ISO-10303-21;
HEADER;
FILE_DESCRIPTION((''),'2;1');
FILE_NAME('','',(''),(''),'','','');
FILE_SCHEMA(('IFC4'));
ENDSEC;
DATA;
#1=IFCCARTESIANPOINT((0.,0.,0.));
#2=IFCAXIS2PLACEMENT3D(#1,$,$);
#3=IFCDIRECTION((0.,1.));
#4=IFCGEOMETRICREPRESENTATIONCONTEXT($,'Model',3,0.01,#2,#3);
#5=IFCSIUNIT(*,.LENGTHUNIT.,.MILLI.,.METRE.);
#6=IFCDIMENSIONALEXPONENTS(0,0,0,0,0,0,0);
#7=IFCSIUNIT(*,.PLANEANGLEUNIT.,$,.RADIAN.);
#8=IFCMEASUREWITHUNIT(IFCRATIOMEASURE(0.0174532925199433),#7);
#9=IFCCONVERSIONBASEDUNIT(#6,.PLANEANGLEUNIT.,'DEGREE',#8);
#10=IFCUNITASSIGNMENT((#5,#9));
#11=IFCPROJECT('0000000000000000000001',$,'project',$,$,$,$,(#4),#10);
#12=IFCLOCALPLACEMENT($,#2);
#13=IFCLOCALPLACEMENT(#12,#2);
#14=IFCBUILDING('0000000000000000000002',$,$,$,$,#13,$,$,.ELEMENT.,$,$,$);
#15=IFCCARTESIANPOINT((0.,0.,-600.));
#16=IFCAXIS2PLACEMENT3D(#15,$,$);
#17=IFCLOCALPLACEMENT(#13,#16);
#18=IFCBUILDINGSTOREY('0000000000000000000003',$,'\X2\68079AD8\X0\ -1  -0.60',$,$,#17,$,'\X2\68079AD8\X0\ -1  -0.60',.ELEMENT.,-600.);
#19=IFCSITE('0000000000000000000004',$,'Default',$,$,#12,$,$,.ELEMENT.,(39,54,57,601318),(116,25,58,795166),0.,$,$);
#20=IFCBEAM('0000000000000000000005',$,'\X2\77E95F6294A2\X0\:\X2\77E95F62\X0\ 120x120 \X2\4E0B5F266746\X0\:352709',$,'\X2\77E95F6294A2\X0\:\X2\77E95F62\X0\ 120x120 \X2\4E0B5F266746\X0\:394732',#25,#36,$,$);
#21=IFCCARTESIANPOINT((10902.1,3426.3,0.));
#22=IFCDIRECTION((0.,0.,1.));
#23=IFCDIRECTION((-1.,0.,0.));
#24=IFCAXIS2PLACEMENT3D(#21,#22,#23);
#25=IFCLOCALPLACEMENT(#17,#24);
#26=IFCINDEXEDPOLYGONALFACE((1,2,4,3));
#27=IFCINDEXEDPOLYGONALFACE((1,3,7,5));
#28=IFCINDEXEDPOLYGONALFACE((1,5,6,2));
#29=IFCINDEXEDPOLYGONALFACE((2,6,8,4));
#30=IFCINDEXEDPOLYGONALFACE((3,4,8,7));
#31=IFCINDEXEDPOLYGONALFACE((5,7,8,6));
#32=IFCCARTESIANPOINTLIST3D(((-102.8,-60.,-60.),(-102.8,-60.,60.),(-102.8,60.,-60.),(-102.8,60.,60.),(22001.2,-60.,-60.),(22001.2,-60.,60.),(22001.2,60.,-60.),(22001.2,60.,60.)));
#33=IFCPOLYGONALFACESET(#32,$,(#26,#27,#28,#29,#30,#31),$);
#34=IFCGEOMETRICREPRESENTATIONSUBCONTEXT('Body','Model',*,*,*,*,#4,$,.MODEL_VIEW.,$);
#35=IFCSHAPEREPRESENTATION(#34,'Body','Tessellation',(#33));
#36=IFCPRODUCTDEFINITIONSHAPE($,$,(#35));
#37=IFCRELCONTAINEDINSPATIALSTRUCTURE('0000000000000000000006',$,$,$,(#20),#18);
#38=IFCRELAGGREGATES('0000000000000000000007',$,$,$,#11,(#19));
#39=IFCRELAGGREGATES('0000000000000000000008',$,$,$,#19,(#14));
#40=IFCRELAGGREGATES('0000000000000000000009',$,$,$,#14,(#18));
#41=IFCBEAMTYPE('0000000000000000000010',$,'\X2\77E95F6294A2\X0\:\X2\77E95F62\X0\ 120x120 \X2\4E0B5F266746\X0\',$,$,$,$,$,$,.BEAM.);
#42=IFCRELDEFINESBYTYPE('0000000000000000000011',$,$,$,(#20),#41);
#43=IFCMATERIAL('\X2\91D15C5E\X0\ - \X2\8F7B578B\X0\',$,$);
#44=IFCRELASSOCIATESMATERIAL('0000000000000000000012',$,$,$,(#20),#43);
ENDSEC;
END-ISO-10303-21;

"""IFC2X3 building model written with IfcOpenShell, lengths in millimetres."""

from ifc_helpers import new_model, entity, si_unit, converted_unit, direction, frame, frame_2d, origin, place, context, subcontext, project, spatial, rectangle, extrude, material, type_object, element, save


model = new_model("IFC2X3")

# Units and contexts
model_context = context("Model", 3, precision=0.01, world=origin(), true_north=direction((0.0, 1.0)))
body_context = subcontext(model_context, "Body", "Model", "MODEL_VIEW")
ifc_project = project(units=[si_unit("LENGTHUNIT", "METRE", prefix="MILLI"), converted_unit("PLANEANGLEUNIT", "DEGREE", entity("IfcRatioMeasure", 0.0174532925199433), si_unit("PLANEANGLEUNIT", "RADIAN"), dimensions=[0, 0, 0, 0, 0, 0, 0])], contexts=[model_context])

# Site, building, storey
site_placement = place(None, origin())
site = spatial("IfcSite", under=ifc_project, at=site_placement, Name="Default", CompositionType="ELEMENT", RefLatitude=(39, 54, 57, 601318), RefLongitude=(116, 25, 58, 795166), RefElevation=0.0)
building_placement = place(site_placement, origin())
building = spatial("IfcBuilding", under=site, at=building_placement, CompositionType="ELEMENT")
storey_placement = place(building_placement, frame((0.0, 0.0, -600.0)))
storey = spatial("IfcBuildingStorey", under=building, at=storey_placement, Name="标高 -1  -0.60", LongName="标高 -1  -0.60", CompositionType="ELEMENT", Elevation=-600.0)

# Shared definitions
ifc_material = material(Name="金属 - 轻型")

# Beam
beam_type = type_object("IfcBeamType", Name="矩形钢:矩形 120x120 下弦杆", PredefinedType="BEAM")
beam_placement = place(storey_placement, frame((10902.1, 3426.3, 0.0), z_axis=(0.0, 0.0, 1.0), x_axis=(-1.0, 0.0, 0.0)))
element("IfcBeam", 1, at=beam_placement, inside=storey, type_object=beam_type, material=ifc_material, Name="矩形钢:矩形 120x120 下弦杆:352709", ObjectType="矩形钢:矩形 120x120 下弦杆:394732", context=body_context, shape_type="SweptSolid", body=[
    extrude(rectangle(XDim=120.0, YDim=120.0, at=frame_2d((0.0, 0.0), x_axis=(1.0, 0.0))), frame((-102.8, 0.0, 0.0), z_axis=(1.0, 0.0, 0.0), x_axis=(0.0, 0.0, -1.0)), (0.0, 0.0, 1.0), 22104.0),
])

save(model, "model.ifc")
